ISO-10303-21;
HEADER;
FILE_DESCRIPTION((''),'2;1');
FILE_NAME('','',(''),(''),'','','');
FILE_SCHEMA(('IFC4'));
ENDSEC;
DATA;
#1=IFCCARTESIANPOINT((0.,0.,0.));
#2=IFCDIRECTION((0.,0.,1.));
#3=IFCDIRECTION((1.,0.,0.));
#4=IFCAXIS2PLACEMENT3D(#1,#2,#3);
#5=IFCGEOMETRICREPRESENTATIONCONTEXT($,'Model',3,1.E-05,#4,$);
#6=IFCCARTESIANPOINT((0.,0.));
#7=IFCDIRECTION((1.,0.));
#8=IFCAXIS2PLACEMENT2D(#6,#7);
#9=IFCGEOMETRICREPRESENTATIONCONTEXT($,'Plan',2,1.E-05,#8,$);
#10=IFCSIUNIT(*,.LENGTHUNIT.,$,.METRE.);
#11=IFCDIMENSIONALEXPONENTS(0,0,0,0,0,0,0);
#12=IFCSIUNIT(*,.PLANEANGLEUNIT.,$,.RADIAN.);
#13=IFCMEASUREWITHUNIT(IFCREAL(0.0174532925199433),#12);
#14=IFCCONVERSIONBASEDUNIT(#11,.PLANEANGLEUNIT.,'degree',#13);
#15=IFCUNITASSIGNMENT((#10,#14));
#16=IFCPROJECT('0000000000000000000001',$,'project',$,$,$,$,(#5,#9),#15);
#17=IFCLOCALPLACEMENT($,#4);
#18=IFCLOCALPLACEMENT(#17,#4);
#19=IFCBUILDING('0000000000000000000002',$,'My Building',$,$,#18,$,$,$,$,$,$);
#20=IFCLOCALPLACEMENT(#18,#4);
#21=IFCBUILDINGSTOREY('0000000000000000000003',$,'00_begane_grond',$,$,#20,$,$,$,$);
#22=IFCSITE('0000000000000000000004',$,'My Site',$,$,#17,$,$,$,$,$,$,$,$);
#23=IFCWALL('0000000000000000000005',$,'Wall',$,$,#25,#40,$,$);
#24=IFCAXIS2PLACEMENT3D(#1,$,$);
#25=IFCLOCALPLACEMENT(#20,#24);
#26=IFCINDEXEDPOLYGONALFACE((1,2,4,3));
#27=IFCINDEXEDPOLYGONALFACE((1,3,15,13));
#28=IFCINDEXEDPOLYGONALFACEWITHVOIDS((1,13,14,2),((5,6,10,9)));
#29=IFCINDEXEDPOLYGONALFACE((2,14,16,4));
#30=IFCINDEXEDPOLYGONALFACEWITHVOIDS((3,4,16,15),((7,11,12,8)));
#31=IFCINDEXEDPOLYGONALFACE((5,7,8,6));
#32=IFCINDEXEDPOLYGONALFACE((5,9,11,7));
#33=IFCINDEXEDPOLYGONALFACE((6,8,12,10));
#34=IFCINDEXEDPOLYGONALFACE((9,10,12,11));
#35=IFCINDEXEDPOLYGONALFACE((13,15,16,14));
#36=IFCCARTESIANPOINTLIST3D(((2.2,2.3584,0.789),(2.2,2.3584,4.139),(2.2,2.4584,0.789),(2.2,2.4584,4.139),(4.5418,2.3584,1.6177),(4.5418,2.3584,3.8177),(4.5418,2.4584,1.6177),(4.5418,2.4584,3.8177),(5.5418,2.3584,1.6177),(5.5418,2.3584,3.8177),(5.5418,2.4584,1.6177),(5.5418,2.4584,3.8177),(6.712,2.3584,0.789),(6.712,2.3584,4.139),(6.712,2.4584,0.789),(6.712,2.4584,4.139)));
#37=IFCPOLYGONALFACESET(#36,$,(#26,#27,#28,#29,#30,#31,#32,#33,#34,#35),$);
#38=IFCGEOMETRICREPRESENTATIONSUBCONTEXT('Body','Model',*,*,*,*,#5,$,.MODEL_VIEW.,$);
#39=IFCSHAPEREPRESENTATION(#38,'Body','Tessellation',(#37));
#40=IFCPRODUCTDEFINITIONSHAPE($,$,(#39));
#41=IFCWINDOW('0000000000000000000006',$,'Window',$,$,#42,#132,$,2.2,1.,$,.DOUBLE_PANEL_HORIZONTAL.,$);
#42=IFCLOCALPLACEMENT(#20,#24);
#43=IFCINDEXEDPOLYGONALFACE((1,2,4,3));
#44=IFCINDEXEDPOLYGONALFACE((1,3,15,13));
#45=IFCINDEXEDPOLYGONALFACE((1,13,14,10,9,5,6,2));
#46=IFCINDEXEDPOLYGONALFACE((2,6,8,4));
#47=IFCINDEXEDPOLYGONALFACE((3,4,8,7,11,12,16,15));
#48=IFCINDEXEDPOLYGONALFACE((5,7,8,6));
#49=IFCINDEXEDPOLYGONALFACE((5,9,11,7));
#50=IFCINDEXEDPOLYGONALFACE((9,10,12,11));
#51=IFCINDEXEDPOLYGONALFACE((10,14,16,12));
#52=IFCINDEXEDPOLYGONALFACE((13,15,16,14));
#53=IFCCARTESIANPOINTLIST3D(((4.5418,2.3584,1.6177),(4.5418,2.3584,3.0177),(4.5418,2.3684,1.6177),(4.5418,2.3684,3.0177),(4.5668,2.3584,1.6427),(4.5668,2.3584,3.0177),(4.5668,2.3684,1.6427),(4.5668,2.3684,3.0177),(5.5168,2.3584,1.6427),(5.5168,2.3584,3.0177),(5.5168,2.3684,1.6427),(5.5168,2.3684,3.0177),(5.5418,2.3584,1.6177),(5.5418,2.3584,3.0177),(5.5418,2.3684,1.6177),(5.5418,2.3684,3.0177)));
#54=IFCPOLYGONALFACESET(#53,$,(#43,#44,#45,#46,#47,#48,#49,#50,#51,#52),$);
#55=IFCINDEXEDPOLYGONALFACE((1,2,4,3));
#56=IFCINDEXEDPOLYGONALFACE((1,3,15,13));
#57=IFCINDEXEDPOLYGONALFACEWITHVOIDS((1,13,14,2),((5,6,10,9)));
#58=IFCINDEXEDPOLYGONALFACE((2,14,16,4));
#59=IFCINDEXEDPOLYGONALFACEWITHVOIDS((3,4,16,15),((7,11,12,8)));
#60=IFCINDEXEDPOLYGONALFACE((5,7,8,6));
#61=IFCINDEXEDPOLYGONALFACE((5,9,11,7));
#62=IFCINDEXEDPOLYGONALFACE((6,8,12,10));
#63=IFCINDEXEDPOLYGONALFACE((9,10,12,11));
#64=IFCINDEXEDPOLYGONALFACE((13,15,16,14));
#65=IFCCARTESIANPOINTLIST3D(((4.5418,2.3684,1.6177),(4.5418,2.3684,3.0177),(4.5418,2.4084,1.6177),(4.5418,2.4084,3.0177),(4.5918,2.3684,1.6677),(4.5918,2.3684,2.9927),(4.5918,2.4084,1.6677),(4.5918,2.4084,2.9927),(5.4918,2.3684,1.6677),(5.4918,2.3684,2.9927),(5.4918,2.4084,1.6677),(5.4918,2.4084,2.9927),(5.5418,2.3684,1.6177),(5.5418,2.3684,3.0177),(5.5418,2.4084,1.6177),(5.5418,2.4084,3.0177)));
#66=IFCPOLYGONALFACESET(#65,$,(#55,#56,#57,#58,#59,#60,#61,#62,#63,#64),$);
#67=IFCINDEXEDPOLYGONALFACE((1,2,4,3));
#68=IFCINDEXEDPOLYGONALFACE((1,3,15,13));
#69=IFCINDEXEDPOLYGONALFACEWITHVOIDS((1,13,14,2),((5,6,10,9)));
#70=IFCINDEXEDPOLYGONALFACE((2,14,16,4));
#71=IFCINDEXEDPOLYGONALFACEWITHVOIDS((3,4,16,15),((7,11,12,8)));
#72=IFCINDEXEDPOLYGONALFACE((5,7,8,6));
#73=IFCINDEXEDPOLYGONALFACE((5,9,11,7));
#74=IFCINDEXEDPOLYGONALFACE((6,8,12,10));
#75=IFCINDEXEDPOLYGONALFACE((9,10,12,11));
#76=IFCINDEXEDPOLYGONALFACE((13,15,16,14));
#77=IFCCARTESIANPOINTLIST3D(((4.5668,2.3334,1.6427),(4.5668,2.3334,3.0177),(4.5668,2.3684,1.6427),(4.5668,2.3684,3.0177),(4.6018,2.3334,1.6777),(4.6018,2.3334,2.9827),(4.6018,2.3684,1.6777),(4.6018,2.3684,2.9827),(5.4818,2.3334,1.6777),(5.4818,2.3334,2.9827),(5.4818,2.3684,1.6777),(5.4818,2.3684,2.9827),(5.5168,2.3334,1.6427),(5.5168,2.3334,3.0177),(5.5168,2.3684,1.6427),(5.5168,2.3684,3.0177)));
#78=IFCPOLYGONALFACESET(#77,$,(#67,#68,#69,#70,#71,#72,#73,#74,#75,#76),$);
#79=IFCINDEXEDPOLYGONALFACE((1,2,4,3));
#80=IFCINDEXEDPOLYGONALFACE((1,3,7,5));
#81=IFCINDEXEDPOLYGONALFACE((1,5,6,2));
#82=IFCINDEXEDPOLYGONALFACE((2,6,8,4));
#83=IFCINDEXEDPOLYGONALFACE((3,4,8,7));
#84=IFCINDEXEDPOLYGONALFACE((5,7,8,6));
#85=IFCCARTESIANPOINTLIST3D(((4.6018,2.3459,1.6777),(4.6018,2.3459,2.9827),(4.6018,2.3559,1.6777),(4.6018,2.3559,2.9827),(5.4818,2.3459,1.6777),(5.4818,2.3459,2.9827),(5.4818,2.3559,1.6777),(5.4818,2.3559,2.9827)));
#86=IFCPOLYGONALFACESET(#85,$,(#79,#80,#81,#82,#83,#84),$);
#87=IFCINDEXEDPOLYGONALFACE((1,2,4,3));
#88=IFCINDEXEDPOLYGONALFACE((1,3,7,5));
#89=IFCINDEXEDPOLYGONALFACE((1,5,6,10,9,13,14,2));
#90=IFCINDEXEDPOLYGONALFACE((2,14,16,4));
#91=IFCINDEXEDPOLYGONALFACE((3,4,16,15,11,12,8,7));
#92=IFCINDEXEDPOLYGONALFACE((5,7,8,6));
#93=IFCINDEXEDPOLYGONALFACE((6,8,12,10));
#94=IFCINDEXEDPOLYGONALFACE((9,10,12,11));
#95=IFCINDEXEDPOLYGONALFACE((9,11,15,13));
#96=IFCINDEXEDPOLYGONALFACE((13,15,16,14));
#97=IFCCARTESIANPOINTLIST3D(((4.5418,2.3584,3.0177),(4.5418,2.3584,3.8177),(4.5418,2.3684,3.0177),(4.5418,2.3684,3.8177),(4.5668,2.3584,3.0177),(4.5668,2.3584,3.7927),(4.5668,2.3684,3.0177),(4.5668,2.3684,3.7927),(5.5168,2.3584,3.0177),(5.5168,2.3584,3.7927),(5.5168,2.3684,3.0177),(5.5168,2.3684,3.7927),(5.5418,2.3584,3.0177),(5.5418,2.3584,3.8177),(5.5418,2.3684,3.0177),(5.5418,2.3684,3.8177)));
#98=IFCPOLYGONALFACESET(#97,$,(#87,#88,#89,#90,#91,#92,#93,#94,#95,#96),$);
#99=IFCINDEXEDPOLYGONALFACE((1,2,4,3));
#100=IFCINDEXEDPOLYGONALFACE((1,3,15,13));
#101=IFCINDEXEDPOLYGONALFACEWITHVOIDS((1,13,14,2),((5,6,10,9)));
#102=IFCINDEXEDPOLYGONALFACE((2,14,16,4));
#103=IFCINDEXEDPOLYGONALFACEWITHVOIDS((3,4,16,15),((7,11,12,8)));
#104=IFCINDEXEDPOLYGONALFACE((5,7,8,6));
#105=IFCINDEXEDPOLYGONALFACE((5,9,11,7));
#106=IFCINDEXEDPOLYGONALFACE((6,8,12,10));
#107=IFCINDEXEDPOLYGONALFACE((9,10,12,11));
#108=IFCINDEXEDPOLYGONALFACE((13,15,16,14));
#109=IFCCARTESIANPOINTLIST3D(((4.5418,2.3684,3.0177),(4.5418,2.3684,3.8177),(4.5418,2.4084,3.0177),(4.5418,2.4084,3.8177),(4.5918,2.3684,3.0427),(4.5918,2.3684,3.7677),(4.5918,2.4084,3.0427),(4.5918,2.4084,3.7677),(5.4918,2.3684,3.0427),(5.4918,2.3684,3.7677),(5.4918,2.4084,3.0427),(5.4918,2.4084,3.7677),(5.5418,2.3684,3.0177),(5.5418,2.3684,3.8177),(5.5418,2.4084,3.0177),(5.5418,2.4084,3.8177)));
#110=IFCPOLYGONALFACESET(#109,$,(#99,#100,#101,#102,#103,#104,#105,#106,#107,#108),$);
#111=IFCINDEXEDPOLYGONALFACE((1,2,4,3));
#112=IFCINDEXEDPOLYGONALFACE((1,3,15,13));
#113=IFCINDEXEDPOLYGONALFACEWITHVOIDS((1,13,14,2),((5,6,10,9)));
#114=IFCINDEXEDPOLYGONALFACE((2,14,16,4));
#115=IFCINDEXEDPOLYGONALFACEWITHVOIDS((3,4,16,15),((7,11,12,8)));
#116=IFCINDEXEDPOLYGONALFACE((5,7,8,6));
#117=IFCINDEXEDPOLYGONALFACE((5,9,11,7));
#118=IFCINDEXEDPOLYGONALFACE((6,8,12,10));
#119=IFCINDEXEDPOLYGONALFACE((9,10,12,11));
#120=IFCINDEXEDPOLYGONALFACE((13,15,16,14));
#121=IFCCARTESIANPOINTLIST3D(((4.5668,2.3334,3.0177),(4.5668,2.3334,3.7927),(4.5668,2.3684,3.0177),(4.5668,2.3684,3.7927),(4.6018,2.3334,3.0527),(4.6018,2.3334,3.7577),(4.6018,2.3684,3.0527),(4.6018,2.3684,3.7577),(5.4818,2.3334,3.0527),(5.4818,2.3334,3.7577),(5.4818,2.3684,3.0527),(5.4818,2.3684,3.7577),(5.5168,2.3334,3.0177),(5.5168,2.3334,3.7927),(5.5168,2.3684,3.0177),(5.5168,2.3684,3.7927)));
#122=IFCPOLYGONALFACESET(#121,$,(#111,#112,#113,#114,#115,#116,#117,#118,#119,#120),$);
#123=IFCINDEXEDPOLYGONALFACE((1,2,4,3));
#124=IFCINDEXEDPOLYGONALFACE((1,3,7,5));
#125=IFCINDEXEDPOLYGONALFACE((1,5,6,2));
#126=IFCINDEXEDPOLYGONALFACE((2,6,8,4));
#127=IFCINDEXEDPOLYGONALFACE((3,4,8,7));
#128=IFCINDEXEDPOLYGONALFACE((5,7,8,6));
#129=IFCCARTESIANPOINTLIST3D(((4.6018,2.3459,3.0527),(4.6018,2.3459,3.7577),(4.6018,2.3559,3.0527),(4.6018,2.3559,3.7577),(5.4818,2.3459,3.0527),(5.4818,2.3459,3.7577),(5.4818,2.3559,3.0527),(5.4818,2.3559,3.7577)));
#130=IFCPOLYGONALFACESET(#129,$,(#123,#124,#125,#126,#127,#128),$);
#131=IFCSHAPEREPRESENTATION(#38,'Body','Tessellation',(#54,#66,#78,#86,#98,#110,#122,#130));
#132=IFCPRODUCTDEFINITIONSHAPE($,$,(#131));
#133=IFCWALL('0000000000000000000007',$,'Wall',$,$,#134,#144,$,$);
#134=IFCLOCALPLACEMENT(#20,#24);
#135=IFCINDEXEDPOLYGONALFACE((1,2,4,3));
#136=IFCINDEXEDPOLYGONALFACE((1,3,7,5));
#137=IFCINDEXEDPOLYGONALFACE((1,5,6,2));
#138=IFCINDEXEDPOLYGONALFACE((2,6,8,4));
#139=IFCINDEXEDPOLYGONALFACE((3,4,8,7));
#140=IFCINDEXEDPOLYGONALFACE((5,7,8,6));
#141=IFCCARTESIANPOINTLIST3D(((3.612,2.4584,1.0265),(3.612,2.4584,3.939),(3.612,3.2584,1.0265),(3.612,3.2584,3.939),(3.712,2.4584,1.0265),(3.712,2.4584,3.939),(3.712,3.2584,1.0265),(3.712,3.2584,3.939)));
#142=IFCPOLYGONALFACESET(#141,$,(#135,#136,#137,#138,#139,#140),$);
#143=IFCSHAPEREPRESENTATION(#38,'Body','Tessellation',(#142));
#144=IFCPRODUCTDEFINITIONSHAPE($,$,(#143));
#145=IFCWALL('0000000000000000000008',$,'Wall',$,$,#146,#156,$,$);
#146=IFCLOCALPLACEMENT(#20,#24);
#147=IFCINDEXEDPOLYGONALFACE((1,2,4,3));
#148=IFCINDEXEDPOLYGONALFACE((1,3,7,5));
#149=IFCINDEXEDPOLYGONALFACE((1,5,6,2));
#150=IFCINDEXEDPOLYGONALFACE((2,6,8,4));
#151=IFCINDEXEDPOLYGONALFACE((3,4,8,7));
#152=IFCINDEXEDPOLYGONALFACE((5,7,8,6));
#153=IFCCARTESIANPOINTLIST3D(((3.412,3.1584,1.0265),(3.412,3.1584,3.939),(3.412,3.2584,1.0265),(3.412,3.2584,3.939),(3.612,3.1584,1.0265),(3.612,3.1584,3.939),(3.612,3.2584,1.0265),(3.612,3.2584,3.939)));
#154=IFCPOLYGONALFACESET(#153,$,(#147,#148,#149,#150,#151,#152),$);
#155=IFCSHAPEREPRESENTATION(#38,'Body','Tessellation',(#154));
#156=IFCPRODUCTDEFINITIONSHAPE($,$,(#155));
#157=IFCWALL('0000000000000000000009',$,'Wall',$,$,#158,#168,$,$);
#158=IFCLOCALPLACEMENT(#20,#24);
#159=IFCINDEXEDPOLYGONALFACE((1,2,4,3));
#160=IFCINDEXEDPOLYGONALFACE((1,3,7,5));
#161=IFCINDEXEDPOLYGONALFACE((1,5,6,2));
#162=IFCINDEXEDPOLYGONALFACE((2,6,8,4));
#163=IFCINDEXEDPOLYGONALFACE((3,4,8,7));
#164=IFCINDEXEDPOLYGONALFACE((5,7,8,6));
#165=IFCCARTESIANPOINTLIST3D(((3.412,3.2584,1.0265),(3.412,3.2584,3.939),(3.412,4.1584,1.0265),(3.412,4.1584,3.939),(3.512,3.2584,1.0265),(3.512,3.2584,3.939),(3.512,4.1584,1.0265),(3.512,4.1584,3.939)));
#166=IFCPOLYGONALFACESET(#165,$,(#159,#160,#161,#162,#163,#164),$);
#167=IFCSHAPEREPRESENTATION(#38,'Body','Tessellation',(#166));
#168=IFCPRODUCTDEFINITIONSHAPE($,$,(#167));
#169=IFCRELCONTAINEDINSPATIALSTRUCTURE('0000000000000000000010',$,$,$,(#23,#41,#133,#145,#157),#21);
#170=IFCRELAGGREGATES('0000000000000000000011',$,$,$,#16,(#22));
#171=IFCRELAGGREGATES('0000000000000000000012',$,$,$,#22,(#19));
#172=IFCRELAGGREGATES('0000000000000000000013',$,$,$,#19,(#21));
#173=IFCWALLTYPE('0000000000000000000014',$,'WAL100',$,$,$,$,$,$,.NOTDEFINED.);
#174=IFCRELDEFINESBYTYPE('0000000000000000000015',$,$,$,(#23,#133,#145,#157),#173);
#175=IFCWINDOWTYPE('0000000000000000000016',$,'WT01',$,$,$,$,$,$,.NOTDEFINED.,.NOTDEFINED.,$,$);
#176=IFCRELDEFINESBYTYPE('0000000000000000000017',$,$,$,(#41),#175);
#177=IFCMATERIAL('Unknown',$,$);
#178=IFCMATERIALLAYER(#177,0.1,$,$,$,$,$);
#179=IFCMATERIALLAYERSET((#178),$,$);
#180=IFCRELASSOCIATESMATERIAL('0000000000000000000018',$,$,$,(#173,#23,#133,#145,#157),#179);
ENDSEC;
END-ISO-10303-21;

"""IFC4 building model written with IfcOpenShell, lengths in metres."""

from ifc_helpers import new_model, entity, si_unit, converted_unit, frame, origin_with_axes, origin_2d_with_axis, place, context, subcontext, project, spatial, line, indexed_curve, outline, extrude, clip, halfspace, shape, source, transform, mapped, material, layer, layer_set, layer_usage, type_object, type_shapes, element, fill, save


model = new_model("IFC4")

# Units and contexts
model_context = context("Model", 3, precision=1e-05, world=origin_with_axes())
plan_context = context("Plan", 2, precision=1e-05, world=origin_2d_with_axis())
body_context_1 = subcontext(model_context, "Body", "Model", "MODEL_VIEW")
body_context_2 = subcontext(plan_context, "Body", "Plan", "PLAN_VIEW")
ifc_project = project(units=[si_unit("LENGTHUNIT", "METRE"), converted_unit("PLANEANGLEUNIT", "degree", entity("IfcReal", 0.0174532925199433), si_unit("PLANEANGLEUNIT", "RADIAN"), dimensions=[0, 0, 0, 0, 0, 0, 0])], contexts=[model_context, plan_context])

# Site, building, storey
site_placement = place(None, origin_with_axes())
site = spatial("IfcSite", under=ifc_project, at=site_placement, Name="My Site")
building_placement = place(site_placement, origin_with_axes())
building = spatial("IfcBuilding", under=site, at=building_placement, Name="My Building")
storey_placement = place(building_placement, origin_with_axes())
storey = spatial("IfcBuildingStorey", under=building, at=storey_placement, Name="00_begane_grond")

# Shared definitions
ifc_material_1 = material(Name="Unknown")

# Wall, opening, window
ifc_layer_1 = layer(ifc_material_1, 0.1)
ifc_layer_set_1 = layer_set([ifc_layer_1])
ifc_layer_usage_1 = layer_usage(ifc_layer_set_1, "AXIS2", "POSITIVE", 0.0)
wall_type_1 = type_object("IfcWallType", Name="WAL100", PredefinedType="NOTDEFINED", material=ifc_layer_set_1)
wall_1_placement = place(storey_placement, frame((6.712, 2.4584, 0.789), z_axis=(0.0, 0.0, 1.0), x_axis=(-1.0, 0.0, 0.0)))
wall_1 = element("IfcWall", 1, at=wall_1_placement, inside=storey, type_object=wall_type_1, material=ifc_layer_usage_1, Name="Wall", context=body_context_1, shape_type="SweptSolid", body=[
    extrude(outline(indexed_curve([(0.0, 0.0), (0.0, 0.1), (4.512, 0.1), (4.512, 0.0), (0.0, 0.0)], self_intersect=False)), origin_with_axes(), (0.0, 0.0, 1.0), 3.35),
])
shared_shape_1 = source(origin_with_axes(), body_context_1, "Body", "SweptSolid", [
    extrude(outline(indexed_curve([(0.0, 0.0), (1.0, 0.0), (1.0, 2.2), (0.0, 2.2)], segments=[line(1, 2, 3, 4, 1)])), frame((0.0, -0.1, 0.0), z_axis=(0.0, -1.0, 0.0), x_axis=(1.0, 0.0, 0.0)), (0.0, 0.0, -1.0), 0.3),
])
opening_1_placement = place(wall_1_placement, frame((1.1702, 0.0, 0.8286), z_axis=(0.0, 0.0, 1.0), x_axis=(1.0, 0.0, 0.0)))
opening_1 = element("IfcOpeningElement", 2, at=opening_1_placement, cuts=wall_1, PredefinedType="OPENING", context=body_context_1, shape_type="MappedRepresentation", body=[
    mapped(shared_shape_1, transform((0.0, 0.0, 0.0), x_axis=(1.0, 0.0, 0.0), y_axis=(0.0, 1.0, 0.0), z_axis=(0.0, 0.0, 1.0), scale=1.0)),
])
window_type = type_object("IfcWindowType", Name="WT01", PartitioningType="NOTDEFINED", PredefinedType="NOTDEFINED")
shared_shape_2 = source(origin_with_axes(), body_context_1, "Body", "SweptSolid", [
    extrude(outline(indexed_curve([(1.0, 1.4), (1.0, 0.0), (0.0, 0.0), (0.0, 1.4), (0.025, 1.4), (0.025, 0.025), (0.975, 0.025), (0.975, 1.4)], segments=[line(1, 2, 3, 4, 5, 6, 7, 8, 1)])), frame((0.0, 0.09, 0.0), z_axis=(0.0, -1.0, 0.0), x_axis=(1.0, 0.0, 0.0)), (0.0, 0.0, -1.0), 0.01),
    extrude(outline(indexed_curve([(0.0, 0.0), (1.0, 0.0), (1.0, 1.4), (0.0, 1.4)], segments=[line(1, 2, 3, 4, 1)]), holes=[indexed_curve([(0.05, 0.05), (0.95, 0.05), (0.95, 1.375), (0.05, 1.375)], segments=[line(1, 2, 3, 4, 1)])]), frame((0.0, 0.05, 0.0), z_axis=(0.0, -1.0, 0.0), x_axis=(1.0, 0.0, 0.0)), (0.0, 0.0, -1.0), 0.04),
    extrude(outline(indexed_curve([(0.0, 0.0), (0.95, 0.0), (0.95, 1.375), (0.0, 1.375)], segments=[line(1, 2, 3, 4, 1)]), holes=[indexed_curve([(0.035, 0.035), (0.915, 0.035), (0.915, 1.34), (0.035, 1.34)], segments=[line(1, 2, 3, 4, 1)])]), frame((0.025, 0.09, 0.025), z_axis=(0.0, -1.0, 0.0), x_axis=(1.0, 0.0, 0.0)), (0.0, 0.0, -1.0), 0.035),
    extrude(outline(indexed_curve([(0.035, 0.035), (0.915, 0.035), (0.915, 1.34), (0.035, 1.34)], segments=[line(1, 2, 3, 4, 1)])), frame((0.025, 0.1025, 0.025), z_axis=(0.0, -1.0, 0.0), x_axis=(1.0, 0.0, 0.0)), (0.0, 0.0, -1.0), 0.01),
    extrude(outline(indexed_curve([(0.0, 0.0), (0.0, 0.8), (1.0, 0.8), (1.0, 0.0), (0.975, 0.0), (0.975, 0.775), (0.025, 0.775), (0.025, 0.0)], segments=[line(1, 2, 3, 4, 5, 6, 7, 8, 1)])), frame((0.0, 0.09, 1.4), z_axis=(0.0, -1.0, 0.0), x_axis=(1.0, 0.0, 0.0)), (0.0, 0.0, -1.0), 0.01),
    extrude(outline(indexed_curve([(0.0, 0.0), (1.0, 0.0), (1.0, 0.8), (0.0, 0.8)], segments=[line(1, 2, 3, 4, 1)]), holes=[indexed_curve([(0.05, 0.025), (0.95, 0.025), (0.95, 0.75), (0.05, 0.75)], segments=[line(1, 2, 3, 4, 1)])]), frame((0.0, 0.05, 1.4), z_axis=(0.0, -1.0, 0.0), x_axis=(1.0, 0.0, 0.0)), (0.0, 0.0, -1.0), 0.04),
    extrude(outline(indexed_curve([(0.0, 0.0), (0.95, 0.0), (0.95, 0.775), (0.0, 0.775)], segments=[line(1, 2, 3, 4, 1)]), holes=[indexed_curve([(0.035, 0.035), (0.915, 0.035), (0.915, 0.74), (0.035, 0.74)], segments=[line(1, 2, 3, 4, 1)])]), frame((0.025, 0.09, 1.4), z_axis=(0.0, -1.0, 0.0), x_axis=(1.0, 0.0, 0.0)), (0.0, 0.0, -1.0), 0.035),
    extrude(outline(indexed_curve([(0.035, 0.035), (0.915, 0.035), (0.915, 0.74), (0.035, 0.74)], segments=[line(1, 2, 3, 4, 1)])), frame((0.025, 0.1025, 1.4), z_axis=(0.0, -1.0, 0.0), x_axis=(1.0, 0.0, 0.0)), (0.0, 0.0, -1.0), 0.01),
])
shared_shape_3 = source(origin_with_axes(), body_context_2, "Body", "Curve2D", [
    entity("IfcIndexedPolyCurve", entity("IfcCartesianPointList2D", [[0.05, 0.05], [0.95, 0.05]])),
    entity("IfcIndexedPolyCurve", entity("IfcCartesianPointList2D", [[0.0, 0.1], [0.025, 0.1], [0.025, 0.09], [0.05, 0.09], [0.05, 0.05], [0.0, 0.05]]), [entity("IfcLineIndex", [1, 2, 3, 4, 5, 6, 1])]),
    entity("IfcIndexedPolyCurve", entity("IfcCartesianPointList2D", [[1.0, 0.1], [0.975, 0.1], [0.975, 0.09], [0.95, 0.09], [0.95, 0.05], [1.0, 0.05]]), [entity("IfcLineIndex", [1, 2, 3, 4, 5, 6, 1])]),
    entity("IfcIndexedPolyCurve", entity("IfcCartesianPointList2D", [[0.025, 0.09], [0.06, 0.09], [0.06, 0.125], [0.025, 0.125]]), [entity("IfcLineIndex", [1, 2, 3, 4, 1])]),
    entity("IfcIndexedPolyCurve", entity("IfcCartesianPointList2D", [[0.975, 0.09], [0.94, 0.09], [0.94, 0.125], [0.975, 0.125]]), [entity("IfcLineIndex", [1, 2, 3, 4, 1])]),
    entity("IfcIndexedPolyCurve", entity("IfcCartesianPointList2D", [[0.06, 0.09], [0.94, 0.09]])),
    entity("IfcIndexedPolyCurve", entity("IfcCartesianPointList2D", [[0.06, 0.125], [0.94, 0.125]])),
    entity("IfcIndexedPolyCurve", entity("IfcCartesianPointList2D", [[0.06, 0.1075], [0.94, 0.1075]])),
])
type_shapes(window_type, [shared_shape_2, shared_shape_3])
window_placement = place(opening_1_placement, frame((0.0, 0.0, 0.0), z_axis=(0.0, 0.0, 1.0), x_axis=(1.0, 0.0, 0.0)))
window = element("IfcWindow", 3, at=window_placement, inside=storey, type_object=window_type, Name="Window", OverallHeight=2.2, OverallWidth=1.0, PartitioningType="DOUBLE_PANEL_HORIZONTAL", shapes=[
    shape(body_context_1, "Body", "MappedRepresentation", [mapped(shared_shape_2, transform((0.0, 0.0, 0.0), x_axis=(1.0, 0.0, 0.0), y_axis=(0.0, 1.0, 0.0), z_axis=(0.0, 0.0, 1.0), scale=1.0))]),
    shape(body_context_2, "Body", "MappedRepresentation", [mapped(shared_shape_3, transform((0.0, 0.0, 0.0), x_axis=(1.0, 0.0, 0.0), y_axis=(0.0, 1.0, 0.0), z_axis=(0.0, 0.0, 1.0), scale=1.0))]),
])
fill(opening_1, window)

# Walls
ifc_layer_usage_2 = layer_usage(ifc_layer_set_1, "AXIS2", "POSITIVE", 0.0)
wall_2_placement = place(storey_placement, frame((3.712, 2.4584, 1.0265), z_axis=(0.0, 0.0, 1.0), x_axis=(0.000001, 1.0, 0.0)))
element("IfcWall", 4, at=wall_2_placement, inside=storey, type_object=wall_type_1, material=ifc_layer_usage_2, Name="Wall", context=body_context_1, shape_type="Clipping", body=[
    clip(extrude(outline(indexed_curve([(0.0, 0.0), (0.0, 0.1), (0.8, 0.1), (0.8, 0.0), (0.0, 0.0)], self_intersect=False)), origin_with_axes(), (0.0, 0.0, 1.0), 3.939), halfspace(frame((0.0, 0.0, 2.9125), z_axis=(0.0, 0.0, 1.0), x_axis=(-1.0, 0.0, 0.0)), False)),
])
ifc_layer_usage_3 = layer_usage(ifc_layer_set_1, "AXIS2", "POSITIVE", 0.0)
wall_3_placement = place(storey_placement, frame((3.612, 3.2584, 1.0265), z_axis=(0.0, 0.0, 1.0), x_axis=(-1.0, 0.000001, 0.0)))
element("IfcWall", 5, at=wall_3_placement, inside=storey, type_object=wall_type_1, material=ifc_layer_usage_3, Name="Wall", context=body_context_1, shape_type="Clipping", body=[
    clip(extrude(outline(indexed_curve([(0.0, 0.0), (0.0, 0.1), (0.2, 0.1), (0.2, 0.0), (0.0, 0.0)], self_intersect=False)), origin_with_axes(), (0.0, 0.0, 1.0), 3.939), halfspace(frame((0.0, 0.0, 2.9125), z_axis=(0.0, 0.0, 1.0), x_axis=(-1.0, 0.0, 0.0)), False)),
])
ifc_layer_usage_4 = layer_usage(ifc_layer_set_1, "AXIS2", "POSITIVE", 0.0)
wall_4_placement = place(storey_placement, frame((3.512, 3.2584, 1.0265), z_axis=(0.0, 0.0, 1.0), x_axis=(0.000001, 1.0, 0.0)))
element("IfcWall", 6, at=wall_4_placement, inside=storey, type_object=wall_type_1, material=ifc_layer_usage_4, Name="Wall", context=body_context_1, shape_type="Clipping", body=[
    clip(extrude(outline(indexed_curve([(0.0, 0.0), (0.0, 0.1), (0.9, 0.1), (0.9, 0.0), (0.0, 0.0)], self_intersect=False)), origin_with_axes(), (0.0, 0.0, 1.0), 3.939), halfspace(frame((0.0, 0.0, 2.9125), z_axis=(0.0, 0.0, 1.0), x_axis=(-1.0, 0.0, 0.0)), False)),
])

save(model, "model.ifc")
